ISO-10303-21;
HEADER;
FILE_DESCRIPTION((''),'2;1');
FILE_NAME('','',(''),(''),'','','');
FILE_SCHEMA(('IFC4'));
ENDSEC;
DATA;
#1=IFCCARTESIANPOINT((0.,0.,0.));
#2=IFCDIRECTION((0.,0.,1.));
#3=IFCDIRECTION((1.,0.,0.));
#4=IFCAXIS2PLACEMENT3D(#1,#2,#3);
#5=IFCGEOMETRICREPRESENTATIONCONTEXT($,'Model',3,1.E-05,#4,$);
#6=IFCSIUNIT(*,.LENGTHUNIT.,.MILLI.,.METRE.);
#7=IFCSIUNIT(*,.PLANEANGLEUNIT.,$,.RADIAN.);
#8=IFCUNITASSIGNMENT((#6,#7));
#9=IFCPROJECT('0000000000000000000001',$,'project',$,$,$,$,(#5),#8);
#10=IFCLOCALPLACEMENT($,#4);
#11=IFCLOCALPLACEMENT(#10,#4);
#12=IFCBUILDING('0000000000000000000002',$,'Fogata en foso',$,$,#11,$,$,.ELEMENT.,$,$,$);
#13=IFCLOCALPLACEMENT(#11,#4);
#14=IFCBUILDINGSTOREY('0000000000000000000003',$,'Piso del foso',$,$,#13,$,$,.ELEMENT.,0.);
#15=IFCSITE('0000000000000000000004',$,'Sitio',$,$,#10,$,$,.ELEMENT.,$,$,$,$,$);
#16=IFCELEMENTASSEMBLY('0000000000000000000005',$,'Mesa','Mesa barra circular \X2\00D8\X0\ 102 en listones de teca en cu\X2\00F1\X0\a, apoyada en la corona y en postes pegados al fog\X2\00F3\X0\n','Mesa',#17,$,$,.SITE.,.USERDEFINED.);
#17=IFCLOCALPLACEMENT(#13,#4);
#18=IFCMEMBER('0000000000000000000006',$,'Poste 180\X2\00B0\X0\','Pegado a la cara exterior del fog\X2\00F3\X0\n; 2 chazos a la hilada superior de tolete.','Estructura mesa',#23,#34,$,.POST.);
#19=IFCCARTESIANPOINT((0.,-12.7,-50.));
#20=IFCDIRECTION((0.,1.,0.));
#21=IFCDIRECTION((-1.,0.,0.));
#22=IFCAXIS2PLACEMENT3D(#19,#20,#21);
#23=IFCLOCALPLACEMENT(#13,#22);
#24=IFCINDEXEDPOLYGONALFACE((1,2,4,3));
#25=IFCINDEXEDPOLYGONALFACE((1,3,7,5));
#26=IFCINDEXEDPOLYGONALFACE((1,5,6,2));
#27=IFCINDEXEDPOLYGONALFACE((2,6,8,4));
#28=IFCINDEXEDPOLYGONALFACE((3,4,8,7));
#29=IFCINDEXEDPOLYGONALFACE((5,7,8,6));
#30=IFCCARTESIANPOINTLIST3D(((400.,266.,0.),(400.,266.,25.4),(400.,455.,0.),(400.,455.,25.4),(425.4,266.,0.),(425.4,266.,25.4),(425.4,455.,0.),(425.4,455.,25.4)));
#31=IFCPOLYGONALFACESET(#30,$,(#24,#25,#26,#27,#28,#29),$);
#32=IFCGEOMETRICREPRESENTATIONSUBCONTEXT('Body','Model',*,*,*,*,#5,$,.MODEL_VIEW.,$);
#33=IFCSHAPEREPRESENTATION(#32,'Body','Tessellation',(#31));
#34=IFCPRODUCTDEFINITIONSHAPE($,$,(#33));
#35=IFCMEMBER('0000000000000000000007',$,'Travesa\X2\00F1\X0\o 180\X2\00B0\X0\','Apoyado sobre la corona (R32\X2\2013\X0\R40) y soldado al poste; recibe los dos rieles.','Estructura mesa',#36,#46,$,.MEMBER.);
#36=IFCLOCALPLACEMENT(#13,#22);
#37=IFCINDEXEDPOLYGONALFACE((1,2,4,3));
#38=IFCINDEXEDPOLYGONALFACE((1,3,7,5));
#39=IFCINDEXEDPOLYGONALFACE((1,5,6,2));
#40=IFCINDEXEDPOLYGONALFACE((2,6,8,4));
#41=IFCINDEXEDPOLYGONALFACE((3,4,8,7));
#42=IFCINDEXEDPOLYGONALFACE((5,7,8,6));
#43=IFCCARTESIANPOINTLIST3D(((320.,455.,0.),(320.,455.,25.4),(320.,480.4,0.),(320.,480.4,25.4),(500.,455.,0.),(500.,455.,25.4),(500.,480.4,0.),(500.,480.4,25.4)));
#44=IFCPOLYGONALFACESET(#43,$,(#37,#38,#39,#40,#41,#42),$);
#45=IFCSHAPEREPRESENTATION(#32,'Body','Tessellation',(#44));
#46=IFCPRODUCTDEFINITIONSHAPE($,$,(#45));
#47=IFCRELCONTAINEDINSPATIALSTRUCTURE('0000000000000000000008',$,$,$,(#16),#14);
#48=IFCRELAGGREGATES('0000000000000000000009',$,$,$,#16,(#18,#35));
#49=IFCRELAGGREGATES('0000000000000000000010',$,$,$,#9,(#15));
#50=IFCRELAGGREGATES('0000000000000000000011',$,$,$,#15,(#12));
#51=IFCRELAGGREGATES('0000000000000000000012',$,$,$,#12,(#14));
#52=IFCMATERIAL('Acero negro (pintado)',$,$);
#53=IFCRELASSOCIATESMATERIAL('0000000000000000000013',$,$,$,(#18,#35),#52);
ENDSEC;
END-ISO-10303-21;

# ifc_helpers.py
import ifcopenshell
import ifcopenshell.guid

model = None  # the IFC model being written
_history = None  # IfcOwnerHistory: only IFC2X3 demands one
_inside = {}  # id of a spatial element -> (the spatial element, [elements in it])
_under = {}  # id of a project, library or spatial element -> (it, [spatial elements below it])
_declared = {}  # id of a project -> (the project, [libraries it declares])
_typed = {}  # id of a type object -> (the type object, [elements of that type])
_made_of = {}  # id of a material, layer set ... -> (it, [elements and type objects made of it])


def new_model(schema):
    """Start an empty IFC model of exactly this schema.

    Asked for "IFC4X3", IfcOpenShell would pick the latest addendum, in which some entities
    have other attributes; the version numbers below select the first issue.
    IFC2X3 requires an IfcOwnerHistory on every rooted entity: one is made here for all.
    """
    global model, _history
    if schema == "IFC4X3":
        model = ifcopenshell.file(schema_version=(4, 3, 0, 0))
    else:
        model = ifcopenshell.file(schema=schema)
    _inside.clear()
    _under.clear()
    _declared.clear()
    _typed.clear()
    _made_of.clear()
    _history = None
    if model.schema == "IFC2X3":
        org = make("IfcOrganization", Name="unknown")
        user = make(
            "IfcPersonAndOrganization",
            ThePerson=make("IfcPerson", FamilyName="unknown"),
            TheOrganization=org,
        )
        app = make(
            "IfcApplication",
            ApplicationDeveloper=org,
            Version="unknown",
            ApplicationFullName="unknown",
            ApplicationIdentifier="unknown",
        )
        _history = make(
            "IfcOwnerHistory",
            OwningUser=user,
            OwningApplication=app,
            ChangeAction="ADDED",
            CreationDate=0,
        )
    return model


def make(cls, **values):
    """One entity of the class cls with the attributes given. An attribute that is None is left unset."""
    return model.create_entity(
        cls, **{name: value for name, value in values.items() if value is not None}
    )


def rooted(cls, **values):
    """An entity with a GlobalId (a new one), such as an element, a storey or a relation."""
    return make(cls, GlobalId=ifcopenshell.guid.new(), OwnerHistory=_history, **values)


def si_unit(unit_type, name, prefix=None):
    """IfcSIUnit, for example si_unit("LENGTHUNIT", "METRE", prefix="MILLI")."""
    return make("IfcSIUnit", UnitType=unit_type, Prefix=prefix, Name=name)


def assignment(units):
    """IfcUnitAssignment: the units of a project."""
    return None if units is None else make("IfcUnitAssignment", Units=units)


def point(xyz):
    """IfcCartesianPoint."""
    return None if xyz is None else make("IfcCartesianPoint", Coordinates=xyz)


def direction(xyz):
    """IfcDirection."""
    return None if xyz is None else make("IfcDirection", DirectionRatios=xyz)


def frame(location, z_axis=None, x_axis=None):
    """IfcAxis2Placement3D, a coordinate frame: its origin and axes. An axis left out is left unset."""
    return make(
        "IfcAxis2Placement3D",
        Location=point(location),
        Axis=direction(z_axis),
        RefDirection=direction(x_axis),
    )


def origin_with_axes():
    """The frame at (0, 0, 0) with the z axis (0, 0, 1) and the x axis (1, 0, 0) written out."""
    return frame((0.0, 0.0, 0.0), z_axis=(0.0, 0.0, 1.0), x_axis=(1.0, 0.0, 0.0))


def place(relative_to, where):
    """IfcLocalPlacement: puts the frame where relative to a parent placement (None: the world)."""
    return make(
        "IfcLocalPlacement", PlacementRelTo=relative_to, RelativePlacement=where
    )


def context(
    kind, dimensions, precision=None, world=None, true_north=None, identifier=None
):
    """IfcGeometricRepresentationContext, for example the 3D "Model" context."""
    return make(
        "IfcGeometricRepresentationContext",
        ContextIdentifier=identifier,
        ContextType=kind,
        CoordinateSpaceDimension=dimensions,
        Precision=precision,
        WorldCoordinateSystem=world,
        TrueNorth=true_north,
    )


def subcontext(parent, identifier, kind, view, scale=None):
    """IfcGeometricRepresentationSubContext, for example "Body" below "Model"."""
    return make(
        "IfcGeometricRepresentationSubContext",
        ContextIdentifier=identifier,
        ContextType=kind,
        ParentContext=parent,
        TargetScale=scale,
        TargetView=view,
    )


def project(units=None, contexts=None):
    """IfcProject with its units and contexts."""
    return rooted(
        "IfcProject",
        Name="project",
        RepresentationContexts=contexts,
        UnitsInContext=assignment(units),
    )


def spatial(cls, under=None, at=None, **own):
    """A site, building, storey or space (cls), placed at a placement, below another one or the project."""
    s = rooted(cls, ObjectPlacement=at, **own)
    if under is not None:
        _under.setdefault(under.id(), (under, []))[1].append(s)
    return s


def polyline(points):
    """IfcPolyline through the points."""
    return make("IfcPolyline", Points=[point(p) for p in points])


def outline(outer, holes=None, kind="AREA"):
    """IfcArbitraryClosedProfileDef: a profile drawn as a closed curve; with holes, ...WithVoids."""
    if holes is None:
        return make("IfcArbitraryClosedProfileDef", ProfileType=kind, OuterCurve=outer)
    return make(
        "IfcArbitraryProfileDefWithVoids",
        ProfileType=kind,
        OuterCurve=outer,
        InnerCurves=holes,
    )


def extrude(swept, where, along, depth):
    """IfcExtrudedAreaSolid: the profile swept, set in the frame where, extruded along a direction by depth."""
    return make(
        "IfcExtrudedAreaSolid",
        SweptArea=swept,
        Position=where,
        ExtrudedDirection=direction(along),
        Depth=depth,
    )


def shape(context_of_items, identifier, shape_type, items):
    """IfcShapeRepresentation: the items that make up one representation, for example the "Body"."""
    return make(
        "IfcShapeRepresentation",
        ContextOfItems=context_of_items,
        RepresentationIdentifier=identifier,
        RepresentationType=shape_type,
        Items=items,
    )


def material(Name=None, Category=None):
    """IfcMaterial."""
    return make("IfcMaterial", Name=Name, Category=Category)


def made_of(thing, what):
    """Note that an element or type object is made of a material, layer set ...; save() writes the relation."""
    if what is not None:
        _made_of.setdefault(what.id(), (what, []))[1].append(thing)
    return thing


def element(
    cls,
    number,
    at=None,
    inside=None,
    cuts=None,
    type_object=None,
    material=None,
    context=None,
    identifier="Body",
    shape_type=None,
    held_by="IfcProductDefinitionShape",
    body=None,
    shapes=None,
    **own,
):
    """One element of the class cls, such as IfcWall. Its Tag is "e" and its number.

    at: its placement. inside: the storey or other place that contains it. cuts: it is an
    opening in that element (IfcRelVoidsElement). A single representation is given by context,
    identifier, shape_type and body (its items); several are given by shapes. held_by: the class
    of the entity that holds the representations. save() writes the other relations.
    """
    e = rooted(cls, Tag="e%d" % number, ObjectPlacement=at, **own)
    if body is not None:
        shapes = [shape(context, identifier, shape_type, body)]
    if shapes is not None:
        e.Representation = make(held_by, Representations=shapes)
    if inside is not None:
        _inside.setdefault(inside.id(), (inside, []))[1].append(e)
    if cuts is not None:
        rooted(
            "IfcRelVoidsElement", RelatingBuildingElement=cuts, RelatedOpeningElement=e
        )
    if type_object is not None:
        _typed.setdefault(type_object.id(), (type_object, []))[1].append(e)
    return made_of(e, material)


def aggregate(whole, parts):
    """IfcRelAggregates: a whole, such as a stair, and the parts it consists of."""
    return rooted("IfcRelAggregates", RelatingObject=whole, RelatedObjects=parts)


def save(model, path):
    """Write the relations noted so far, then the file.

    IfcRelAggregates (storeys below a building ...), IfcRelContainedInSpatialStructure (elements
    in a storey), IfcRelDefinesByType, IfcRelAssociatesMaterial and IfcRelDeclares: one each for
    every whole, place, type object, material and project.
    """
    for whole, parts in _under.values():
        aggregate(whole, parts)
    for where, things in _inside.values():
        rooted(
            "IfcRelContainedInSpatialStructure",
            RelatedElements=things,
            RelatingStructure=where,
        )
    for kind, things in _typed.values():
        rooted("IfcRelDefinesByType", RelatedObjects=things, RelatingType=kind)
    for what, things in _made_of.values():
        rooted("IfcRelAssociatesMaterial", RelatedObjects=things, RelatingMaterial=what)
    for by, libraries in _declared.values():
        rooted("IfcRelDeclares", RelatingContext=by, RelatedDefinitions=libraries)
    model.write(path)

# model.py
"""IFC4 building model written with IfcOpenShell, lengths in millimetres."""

from ifc_helpers import new_model, si_unit, frame, origin_with_axes, place, context, subcontext, project, spatial, polyline, outline, extrude, material, element, aggregate, save


model = new_model("IFC4")

# Units and contexts
model_context = context("Model", 3, precision=1e-05, world=origin_with_axes())
body_context = subcontext(model_context, "Body", "Model", "MODEL_VIEW")
ifc_project = project(units=[si_unit("LENGTHUNIT", "METRE", prefix="MILLI"), si_unit("PLANEANGLEUNIT", "RADIAN")], contexts=[model_context])

# Site, building, storey
site_placement = place(None, origin_with_axes())
site = spatial("IfcSite", under=ifc_project, at=site_placement, Name="Sitio", CompositionType="ELEMENT")
building_placement = place(site_placement, origin_with_axes())
building = spatial("IfcBuilding", under=site, at=building_placement, Name="Fogata en foso", CompositionType="ELEMENT")
storey_placement = place(building_placement, origin_with_axes())
storey = spatial("IfcBuildingStorey", under=building, at=storey_placement, Name="Piso del foso", CompositionType="ELEMENT", Elevation=0.0)

# Element assembly, members
assembly_1_placement = place(storey_placement, origin_with_axes())
assembly_1 = element("IfcElementAssembly", 1, at=assembly_1_placement, inside=storey, Name="Mesa", Description="Mesa barra circular Ø 102 en listones de teca en cuña, apoyada en la corona y en postes pegados al fogón", ObjectType="Mesa", AssemblyPlace="SITE", PredefinedType="USERDEFINED")
ifc_material_1 = material(Name="Acero negro (pintado)")
member_1_placement = place(storey_placement, frame((0.0, -12.7, -50.0), z_axis=(0.0, 1.0, 0.0), x_axis=(-1.0, 0.0, 0.0)))
member_1 = element("IfcMember", 2, at=member_1_placement, material=ifc_material_1, Name="Poste 180°", Description="Pegado a la cara exterior del fogón; 2 chazos a la hilada superior de tolete.", ObjectType="Estructura mesa", PredefinedType="POST", context=body_context, shape_type="SweptSolid", body=[
    extrude(outline(polyline([(400.0, 266.0), (425.4, 266.0), (425.4, 455.0), (400.0, 455.0), (400.0, 266.0)])), origin_with_axes(), (0.0, 0.0, 1.0), 25.4),
])
member_2_placement = place(storey_placement, frame((0.0, -12.7, -50.0), z_axis=(0.0, 1.0, 0.0), x_axis=(-1.0, 0.0, 0.0)))
member_2 = element("IfcMember", 3, at=member_2_placement, material=ifc_material_1, Name="Travesaño 180°", Description="Apoyado sobre la corona (R32–R40) y soldado al poste; recibe los dos rieles.", ObjectType="Estructura mesa", PredefinedType="MEMBER", context=body_context, shape_type="SweptSolid", body=[
    extrude(outline(polyline([(320.0, 455.0), (500.0, 455.0), (500.0, 480.4), (320.0, 480.4), (320.0, 455.0)])), origin_with_axes(), (0.0, 0.0, 1.0), 25.4),
])

aggregate(assembly_1, [member_1, member_2])

save(model, "model.ifc")
